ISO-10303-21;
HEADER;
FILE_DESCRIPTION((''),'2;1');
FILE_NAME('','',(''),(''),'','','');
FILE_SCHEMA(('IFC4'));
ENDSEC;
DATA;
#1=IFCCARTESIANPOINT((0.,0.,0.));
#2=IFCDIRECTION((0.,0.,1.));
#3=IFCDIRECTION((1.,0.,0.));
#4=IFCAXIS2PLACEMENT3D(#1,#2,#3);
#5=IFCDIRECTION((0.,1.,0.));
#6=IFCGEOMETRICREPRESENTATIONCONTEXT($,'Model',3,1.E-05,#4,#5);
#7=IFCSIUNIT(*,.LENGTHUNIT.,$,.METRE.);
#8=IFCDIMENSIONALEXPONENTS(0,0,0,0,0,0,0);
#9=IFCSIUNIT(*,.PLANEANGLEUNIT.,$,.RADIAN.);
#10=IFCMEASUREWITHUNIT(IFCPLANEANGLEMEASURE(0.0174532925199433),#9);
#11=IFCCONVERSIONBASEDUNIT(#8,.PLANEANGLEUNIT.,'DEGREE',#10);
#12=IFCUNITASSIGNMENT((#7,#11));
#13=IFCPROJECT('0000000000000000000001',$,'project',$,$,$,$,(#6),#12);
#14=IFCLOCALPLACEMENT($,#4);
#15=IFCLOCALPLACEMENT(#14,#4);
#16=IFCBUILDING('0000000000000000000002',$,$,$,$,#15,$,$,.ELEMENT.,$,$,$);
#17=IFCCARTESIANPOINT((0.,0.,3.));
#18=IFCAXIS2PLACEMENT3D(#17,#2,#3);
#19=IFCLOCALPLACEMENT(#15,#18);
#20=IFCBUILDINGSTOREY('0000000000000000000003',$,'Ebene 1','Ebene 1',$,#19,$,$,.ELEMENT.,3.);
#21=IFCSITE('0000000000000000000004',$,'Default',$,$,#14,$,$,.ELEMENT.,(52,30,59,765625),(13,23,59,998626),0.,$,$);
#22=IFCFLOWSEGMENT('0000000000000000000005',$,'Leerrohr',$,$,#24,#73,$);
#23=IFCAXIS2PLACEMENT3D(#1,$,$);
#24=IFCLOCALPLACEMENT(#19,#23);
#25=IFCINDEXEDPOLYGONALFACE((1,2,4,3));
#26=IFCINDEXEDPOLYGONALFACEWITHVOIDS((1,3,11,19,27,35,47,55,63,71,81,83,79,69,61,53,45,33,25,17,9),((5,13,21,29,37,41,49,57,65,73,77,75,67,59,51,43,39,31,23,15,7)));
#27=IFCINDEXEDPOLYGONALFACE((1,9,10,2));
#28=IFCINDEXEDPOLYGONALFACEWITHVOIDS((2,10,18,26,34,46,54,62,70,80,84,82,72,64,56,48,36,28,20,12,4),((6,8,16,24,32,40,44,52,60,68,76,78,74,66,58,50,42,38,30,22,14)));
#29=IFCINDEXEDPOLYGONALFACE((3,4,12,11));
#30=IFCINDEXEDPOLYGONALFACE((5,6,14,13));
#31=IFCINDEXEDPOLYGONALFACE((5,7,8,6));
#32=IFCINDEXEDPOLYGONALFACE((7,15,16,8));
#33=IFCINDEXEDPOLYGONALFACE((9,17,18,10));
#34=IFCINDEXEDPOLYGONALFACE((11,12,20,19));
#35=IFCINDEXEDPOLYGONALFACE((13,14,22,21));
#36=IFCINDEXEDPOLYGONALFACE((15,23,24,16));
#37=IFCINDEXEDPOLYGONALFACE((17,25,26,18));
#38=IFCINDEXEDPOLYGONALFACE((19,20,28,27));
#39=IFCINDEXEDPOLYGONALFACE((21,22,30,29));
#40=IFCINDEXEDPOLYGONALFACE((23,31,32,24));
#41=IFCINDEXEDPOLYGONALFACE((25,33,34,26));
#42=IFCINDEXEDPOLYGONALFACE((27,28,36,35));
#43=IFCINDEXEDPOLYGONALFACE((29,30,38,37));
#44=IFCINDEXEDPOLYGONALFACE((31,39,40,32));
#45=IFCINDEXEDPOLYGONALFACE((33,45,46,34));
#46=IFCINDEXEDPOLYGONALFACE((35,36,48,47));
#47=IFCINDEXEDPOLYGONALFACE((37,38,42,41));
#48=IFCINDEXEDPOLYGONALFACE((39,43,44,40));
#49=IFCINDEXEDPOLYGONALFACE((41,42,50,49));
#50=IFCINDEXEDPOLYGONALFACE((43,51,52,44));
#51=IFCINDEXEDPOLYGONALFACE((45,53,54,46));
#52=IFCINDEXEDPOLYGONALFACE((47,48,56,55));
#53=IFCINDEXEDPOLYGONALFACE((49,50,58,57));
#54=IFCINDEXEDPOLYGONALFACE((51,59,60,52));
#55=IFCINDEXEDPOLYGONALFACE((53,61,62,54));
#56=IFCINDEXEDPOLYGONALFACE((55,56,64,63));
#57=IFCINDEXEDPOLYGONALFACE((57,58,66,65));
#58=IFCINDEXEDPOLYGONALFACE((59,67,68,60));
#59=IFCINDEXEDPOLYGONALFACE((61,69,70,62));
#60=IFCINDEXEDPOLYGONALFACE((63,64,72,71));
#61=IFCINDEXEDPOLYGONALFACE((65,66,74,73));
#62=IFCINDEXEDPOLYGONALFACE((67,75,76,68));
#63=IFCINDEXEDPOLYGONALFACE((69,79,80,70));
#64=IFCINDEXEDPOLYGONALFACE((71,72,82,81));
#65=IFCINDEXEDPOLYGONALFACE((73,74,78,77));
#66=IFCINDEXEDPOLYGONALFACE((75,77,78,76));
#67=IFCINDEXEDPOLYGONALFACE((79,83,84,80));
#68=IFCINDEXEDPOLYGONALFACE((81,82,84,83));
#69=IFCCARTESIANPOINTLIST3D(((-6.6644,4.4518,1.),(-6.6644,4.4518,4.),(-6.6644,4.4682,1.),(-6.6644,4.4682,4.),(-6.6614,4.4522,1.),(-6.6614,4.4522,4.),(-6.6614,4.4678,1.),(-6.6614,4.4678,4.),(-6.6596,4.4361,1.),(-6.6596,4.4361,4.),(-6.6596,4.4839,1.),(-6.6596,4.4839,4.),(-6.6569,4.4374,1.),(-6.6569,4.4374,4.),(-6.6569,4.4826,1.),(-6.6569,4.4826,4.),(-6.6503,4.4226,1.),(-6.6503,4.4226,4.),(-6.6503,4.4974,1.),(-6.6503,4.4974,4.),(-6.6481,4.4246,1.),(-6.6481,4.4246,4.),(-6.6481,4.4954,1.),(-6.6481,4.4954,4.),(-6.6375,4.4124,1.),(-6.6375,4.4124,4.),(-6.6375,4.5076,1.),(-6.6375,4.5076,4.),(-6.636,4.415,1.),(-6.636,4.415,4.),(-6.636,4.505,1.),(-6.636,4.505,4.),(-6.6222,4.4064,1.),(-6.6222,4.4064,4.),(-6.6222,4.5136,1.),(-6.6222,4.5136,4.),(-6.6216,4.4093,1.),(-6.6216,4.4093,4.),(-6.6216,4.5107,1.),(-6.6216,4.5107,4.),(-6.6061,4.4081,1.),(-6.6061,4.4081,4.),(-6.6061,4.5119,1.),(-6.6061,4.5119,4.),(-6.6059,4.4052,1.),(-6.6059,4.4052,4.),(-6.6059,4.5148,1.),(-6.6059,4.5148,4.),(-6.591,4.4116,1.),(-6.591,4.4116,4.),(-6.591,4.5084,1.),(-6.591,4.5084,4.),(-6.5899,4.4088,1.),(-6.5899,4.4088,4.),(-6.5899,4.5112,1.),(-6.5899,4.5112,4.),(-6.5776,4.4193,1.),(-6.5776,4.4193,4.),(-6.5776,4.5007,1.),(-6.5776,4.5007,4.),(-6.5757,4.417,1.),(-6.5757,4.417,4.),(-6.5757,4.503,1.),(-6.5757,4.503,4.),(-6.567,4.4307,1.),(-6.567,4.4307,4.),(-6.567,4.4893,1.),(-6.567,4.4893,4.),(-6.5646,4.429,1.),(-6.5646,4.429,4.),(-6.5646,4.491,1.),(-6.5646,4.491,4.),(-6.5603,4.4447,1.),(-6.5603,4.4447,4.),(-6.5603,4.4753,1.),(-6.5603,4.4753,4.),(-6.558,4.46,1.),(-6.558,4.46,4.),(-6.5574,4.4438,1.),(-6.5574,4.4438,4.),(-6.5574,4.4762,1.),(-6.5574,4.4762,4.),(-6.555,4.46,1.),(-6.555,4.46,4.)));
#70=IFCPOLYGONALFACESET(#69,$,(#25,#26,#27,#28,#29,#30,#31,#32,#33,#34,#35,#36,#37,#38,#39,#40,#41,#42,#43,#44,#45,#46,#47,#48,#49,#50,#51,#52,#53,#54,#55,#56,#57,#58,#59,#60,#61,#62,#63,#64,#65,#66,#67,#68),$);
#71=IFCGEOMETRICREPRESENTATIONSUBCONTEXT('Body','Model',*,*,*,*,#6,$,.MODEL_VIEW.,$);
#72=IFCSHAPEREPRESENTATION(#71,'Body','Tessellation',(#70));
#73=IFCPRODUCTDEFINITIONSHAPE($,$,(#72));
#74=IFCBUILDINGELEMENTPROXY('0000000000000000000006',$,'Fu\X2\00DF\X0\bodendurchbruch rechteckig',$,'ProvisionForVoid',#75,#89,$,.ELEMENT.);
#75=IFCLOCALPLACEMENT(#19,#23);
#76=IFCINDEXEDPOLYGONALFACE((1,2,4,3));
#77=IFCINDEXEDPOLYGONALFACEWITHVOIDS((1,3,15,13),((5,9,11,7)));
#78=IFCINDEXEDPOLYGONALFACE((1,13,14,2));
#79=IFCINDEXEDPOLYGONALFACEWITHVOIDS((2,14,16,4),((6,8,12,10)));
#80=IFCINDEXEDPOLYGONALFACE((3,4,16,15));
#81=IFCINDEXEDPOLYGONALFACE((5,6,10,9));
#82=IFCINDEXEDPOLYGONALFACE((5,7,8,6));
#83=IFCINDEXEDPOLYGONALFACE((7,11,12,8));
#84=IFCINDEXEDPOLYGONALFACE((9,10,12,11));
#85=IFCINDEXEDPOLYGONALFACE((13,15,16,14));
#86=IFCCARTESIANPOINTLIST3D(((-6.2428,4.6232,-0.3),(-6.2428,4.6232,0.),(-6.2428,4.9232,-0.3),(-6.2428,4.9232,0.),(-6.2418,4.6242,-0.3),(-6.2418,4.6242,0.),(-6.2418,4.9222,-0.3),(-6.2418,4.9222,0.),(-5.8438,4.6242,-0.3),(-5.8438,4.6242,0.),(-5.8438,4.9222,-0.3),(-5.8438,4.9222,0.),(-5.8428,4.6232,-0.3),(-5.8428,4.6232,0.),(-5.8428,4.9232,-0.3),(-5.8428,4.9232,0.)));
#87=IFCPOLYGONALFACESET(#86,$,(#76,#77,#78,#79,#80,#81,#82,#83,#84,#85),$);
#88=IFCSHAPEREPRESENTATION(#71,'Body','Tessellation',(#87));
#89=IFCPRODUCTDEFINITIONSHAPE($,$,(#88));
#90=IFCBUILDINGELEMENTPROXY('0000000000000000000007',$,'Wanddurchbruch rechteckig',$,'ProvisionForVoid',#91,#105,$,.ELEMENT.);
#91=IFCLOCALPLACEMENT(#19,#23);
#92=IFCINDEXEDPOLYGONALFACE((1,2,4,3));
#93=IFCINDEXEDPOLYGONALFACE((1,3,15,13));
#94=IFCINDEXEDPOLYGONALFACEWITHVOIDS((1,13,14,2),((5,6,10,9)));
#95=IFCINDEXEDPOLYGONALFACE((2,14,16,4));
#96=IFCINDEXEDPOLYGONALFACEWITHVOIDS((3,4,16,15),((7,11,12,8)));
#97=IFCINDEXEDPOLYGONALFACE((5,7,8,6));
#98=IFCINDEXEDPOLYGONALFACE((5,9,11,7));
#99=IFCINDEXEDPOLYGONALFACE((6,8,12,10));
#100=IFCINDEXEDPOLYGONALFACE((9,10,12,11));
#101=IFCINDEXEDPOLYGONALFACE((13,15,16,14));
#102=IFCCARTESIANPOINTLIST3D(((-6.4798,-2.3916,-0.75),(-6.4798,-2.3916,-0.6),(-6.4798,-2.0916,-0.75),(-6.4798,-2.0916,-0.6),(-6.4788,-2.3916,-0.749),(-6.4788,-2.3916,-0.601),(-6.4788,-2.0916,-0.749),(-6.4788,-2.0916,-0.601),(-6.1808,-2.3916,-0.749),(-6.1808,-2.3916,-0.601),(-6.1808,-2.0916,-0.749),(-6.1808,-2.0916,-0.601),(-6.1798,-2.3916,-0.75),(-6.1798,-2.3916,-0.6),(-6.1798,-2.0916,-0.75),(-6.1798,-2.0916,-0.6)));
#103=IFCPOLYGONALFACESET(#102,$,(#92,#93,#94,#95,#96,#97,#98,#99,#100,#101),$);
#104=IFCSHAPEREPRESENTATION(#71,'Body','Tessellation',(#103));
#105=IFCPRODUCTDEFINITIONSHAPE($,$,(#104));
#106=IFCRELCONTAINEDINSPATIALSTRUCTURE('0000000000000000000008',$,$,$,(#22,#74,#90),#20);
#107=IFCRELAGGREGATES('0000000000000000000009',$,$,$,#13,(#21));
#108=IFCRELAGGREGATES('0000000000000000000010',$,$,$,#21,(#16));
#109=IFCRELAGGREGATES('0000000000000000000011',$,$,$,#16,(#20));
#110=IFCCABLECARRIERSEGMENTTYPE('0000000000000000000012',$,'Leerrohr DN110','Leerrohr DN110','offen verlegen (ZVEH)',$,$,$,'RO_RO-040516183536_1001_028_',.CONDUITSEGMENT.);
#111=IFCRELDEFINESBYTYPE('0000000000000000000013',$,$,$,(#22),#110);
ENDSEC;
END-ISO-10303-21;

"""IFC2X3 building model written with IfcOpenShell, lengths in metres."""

from ifc_helpers import new_model, entity, si_unit, converted_unit, direction, frame, origin_with_axes, origin_2d_with_axis, place, context, subcontext, project, spatial, hollow_rectangle, hollow_circle, extrude, source, transform, mapped, type_object, element, save


model = new_model("IFC2X3")

# Units and contexts
model_context = context("Model", 3, precision=1e-05, world=origin_with_axes(), true_north=direction((0.0, 1.0, 0.0)))
body_context = subcontext(model_context, "Body", "Model", "MODEL_VIEW")
ifc_project = project(units=[si_unit("LENGTHUNIT", "METRE"), converted_unit("PLANEANGLEUNIT", "DEGREE", entity("IfcPlaneAngleMeasure", 0.0174532925199433), si_unit("PLANEANGLEUNIT", "RADIAN"), dimensions=[0, 0, 0, 0, 0, 0, 0])], contexts=[model_context])

# Site, building, storey
site_placement = place(None, origin_with_axes())
site = spatial("IfcSite", under=ifc_project, at=site_placement, Name="Default", CompositionType="ELEMENT", RefLatitude=(52, 30, 59, 765625), RefLongitude=(13, 23, 59, 998626), RefElevation=0.0)
building_placement = place(site_placement, origin_with_axes())
building = spatial("IfcBuilding", under=site, at=building_placement, CompositionType="ELEMENT")
storey_placement = place(building_placement, frame((0.0, 0.0, 3.0), z_axis=(0.0, 0.0, 1.0), x_axis=(1.0, 0.0, 0.0)))
storey = spatial("IfcBuildingStorey", under=building, at=storey_placement, Name="Ebene 1", Description="Ebene 1", CompositionType="ELEMENT", Elevation=3.0)

# Flow segment
cable_carrier_segment_type = type_object("IfcCableCarrierSegmentType", Name="Leerrohr DN110", Description="Leerrohr DN110", ApplicableOccurrence="offen verlegen (ZVEH)", ElementType="RO_RO-040516183536_1001_028_", PredefinedType="CONDUITSEGMENT")
flow_segment_placement = place(storey_placement, frame((-6.61, 4.46, 1.0), z_axis=(-1.0, 0.0, 0.0), x_axis=(0.0, 0.0, 1.0)))
element("IfcFlowSegment", 1, at=flow_segment_placement, inside=storey, type_object=cable_carrier_segment_type, Name="Leerrohr", context=body_context, shape_type="SweptSolid", body=[
    extrude(hollow_circle(Radius=0.055, WallThickness=0.003, at=origin_2d_with_axis()), frame((0.0, 0.0, 0.0), z_axis=(1.0, 0.0, 0.0), x_axis=(0.0, 0.0, -1.0)), (0.0, 0.0, 1.0), 3.0),
])

# Building element proxies
shared_shape_1 = source(origin_with_axes(), body_context, "Body", "SweptSolid", [
    extrude(hollow_rectangle(XDim=0.4, YDim=0.3, WallThickness=0.001, at=origin_2d_with_axis()), frame((0.2, 0.15, -0.3), z_axis=(0.0, 0.0, 1.0), x_axis=(1.0, 0.0, 0.0)), (0.0, 0.0, 1.0), 0.3),
])
proxy_1_placement = place(storey_placement, frame((-6.2428, 4.6232, 0.0), z_axis=(0.0, 0.0, 1.0), x_axis=(1.0, 0.0, 0.0)))
element("IfcBuildingElementProxy", 2, at=proxy_1_placement, inside=storey, Name="Fußbodendurchbruch rechteckig", ObjectType="ProvisionForVoid", CompositionType="ELEMENT", context=body_context, shape_type="MappedRepresentation", body=[
    mapped(shared_shape_1, transform((0.0, 0.0, 0.0), x_axis=(1.0, 0.0, 0.0), y_axis=(0.0, 1.0, 0.0), z_axis=(0.0, 0.0, 1.0), scale=1.0)),
])
shared_shape_2 = source(origin_with_axes(), body_context, "Body", "SweptSolid", [
    extrude(hollow_rectangle(XDim=0.3, YDim=0.15, WallThickness=0.001, at=origin_2d_with_axis()), frame((0.15, 0.3, -0.075), z_axis=(0.0, -1.0, 0.0), x_axis=(1.0, 0.0, 0.0)), (0.0, 0.0, 1.0), 0.3),
])
proxy_2_placement = place(storey_placement, frame((-6.4798, -2.3916, -0.6), z_axis=(0.0, 0.0, 1.0), x_axis=(1.0, 0.0, 0.0)))
element("IfcBuildingElementProxy", 3, at=proxy_2_placement, inside=storey, Name="Wanddurchbruch rechteckig", ObjectType="ProvisionForVoid", CompositionType="ELEMENT", context=body_context, shape_type="MappedRepresentation", body=[
    mapped(shared_shape_2, transform((0.0, 0.0, 0.0), x_axis=(1.0, 0.0, 0.0), y_axis=(0.0, 1.0, 0.0), z_axis=(0.0, 0.0, 1.0), scale=1.0)),
])

save(model, "model.ifc")
